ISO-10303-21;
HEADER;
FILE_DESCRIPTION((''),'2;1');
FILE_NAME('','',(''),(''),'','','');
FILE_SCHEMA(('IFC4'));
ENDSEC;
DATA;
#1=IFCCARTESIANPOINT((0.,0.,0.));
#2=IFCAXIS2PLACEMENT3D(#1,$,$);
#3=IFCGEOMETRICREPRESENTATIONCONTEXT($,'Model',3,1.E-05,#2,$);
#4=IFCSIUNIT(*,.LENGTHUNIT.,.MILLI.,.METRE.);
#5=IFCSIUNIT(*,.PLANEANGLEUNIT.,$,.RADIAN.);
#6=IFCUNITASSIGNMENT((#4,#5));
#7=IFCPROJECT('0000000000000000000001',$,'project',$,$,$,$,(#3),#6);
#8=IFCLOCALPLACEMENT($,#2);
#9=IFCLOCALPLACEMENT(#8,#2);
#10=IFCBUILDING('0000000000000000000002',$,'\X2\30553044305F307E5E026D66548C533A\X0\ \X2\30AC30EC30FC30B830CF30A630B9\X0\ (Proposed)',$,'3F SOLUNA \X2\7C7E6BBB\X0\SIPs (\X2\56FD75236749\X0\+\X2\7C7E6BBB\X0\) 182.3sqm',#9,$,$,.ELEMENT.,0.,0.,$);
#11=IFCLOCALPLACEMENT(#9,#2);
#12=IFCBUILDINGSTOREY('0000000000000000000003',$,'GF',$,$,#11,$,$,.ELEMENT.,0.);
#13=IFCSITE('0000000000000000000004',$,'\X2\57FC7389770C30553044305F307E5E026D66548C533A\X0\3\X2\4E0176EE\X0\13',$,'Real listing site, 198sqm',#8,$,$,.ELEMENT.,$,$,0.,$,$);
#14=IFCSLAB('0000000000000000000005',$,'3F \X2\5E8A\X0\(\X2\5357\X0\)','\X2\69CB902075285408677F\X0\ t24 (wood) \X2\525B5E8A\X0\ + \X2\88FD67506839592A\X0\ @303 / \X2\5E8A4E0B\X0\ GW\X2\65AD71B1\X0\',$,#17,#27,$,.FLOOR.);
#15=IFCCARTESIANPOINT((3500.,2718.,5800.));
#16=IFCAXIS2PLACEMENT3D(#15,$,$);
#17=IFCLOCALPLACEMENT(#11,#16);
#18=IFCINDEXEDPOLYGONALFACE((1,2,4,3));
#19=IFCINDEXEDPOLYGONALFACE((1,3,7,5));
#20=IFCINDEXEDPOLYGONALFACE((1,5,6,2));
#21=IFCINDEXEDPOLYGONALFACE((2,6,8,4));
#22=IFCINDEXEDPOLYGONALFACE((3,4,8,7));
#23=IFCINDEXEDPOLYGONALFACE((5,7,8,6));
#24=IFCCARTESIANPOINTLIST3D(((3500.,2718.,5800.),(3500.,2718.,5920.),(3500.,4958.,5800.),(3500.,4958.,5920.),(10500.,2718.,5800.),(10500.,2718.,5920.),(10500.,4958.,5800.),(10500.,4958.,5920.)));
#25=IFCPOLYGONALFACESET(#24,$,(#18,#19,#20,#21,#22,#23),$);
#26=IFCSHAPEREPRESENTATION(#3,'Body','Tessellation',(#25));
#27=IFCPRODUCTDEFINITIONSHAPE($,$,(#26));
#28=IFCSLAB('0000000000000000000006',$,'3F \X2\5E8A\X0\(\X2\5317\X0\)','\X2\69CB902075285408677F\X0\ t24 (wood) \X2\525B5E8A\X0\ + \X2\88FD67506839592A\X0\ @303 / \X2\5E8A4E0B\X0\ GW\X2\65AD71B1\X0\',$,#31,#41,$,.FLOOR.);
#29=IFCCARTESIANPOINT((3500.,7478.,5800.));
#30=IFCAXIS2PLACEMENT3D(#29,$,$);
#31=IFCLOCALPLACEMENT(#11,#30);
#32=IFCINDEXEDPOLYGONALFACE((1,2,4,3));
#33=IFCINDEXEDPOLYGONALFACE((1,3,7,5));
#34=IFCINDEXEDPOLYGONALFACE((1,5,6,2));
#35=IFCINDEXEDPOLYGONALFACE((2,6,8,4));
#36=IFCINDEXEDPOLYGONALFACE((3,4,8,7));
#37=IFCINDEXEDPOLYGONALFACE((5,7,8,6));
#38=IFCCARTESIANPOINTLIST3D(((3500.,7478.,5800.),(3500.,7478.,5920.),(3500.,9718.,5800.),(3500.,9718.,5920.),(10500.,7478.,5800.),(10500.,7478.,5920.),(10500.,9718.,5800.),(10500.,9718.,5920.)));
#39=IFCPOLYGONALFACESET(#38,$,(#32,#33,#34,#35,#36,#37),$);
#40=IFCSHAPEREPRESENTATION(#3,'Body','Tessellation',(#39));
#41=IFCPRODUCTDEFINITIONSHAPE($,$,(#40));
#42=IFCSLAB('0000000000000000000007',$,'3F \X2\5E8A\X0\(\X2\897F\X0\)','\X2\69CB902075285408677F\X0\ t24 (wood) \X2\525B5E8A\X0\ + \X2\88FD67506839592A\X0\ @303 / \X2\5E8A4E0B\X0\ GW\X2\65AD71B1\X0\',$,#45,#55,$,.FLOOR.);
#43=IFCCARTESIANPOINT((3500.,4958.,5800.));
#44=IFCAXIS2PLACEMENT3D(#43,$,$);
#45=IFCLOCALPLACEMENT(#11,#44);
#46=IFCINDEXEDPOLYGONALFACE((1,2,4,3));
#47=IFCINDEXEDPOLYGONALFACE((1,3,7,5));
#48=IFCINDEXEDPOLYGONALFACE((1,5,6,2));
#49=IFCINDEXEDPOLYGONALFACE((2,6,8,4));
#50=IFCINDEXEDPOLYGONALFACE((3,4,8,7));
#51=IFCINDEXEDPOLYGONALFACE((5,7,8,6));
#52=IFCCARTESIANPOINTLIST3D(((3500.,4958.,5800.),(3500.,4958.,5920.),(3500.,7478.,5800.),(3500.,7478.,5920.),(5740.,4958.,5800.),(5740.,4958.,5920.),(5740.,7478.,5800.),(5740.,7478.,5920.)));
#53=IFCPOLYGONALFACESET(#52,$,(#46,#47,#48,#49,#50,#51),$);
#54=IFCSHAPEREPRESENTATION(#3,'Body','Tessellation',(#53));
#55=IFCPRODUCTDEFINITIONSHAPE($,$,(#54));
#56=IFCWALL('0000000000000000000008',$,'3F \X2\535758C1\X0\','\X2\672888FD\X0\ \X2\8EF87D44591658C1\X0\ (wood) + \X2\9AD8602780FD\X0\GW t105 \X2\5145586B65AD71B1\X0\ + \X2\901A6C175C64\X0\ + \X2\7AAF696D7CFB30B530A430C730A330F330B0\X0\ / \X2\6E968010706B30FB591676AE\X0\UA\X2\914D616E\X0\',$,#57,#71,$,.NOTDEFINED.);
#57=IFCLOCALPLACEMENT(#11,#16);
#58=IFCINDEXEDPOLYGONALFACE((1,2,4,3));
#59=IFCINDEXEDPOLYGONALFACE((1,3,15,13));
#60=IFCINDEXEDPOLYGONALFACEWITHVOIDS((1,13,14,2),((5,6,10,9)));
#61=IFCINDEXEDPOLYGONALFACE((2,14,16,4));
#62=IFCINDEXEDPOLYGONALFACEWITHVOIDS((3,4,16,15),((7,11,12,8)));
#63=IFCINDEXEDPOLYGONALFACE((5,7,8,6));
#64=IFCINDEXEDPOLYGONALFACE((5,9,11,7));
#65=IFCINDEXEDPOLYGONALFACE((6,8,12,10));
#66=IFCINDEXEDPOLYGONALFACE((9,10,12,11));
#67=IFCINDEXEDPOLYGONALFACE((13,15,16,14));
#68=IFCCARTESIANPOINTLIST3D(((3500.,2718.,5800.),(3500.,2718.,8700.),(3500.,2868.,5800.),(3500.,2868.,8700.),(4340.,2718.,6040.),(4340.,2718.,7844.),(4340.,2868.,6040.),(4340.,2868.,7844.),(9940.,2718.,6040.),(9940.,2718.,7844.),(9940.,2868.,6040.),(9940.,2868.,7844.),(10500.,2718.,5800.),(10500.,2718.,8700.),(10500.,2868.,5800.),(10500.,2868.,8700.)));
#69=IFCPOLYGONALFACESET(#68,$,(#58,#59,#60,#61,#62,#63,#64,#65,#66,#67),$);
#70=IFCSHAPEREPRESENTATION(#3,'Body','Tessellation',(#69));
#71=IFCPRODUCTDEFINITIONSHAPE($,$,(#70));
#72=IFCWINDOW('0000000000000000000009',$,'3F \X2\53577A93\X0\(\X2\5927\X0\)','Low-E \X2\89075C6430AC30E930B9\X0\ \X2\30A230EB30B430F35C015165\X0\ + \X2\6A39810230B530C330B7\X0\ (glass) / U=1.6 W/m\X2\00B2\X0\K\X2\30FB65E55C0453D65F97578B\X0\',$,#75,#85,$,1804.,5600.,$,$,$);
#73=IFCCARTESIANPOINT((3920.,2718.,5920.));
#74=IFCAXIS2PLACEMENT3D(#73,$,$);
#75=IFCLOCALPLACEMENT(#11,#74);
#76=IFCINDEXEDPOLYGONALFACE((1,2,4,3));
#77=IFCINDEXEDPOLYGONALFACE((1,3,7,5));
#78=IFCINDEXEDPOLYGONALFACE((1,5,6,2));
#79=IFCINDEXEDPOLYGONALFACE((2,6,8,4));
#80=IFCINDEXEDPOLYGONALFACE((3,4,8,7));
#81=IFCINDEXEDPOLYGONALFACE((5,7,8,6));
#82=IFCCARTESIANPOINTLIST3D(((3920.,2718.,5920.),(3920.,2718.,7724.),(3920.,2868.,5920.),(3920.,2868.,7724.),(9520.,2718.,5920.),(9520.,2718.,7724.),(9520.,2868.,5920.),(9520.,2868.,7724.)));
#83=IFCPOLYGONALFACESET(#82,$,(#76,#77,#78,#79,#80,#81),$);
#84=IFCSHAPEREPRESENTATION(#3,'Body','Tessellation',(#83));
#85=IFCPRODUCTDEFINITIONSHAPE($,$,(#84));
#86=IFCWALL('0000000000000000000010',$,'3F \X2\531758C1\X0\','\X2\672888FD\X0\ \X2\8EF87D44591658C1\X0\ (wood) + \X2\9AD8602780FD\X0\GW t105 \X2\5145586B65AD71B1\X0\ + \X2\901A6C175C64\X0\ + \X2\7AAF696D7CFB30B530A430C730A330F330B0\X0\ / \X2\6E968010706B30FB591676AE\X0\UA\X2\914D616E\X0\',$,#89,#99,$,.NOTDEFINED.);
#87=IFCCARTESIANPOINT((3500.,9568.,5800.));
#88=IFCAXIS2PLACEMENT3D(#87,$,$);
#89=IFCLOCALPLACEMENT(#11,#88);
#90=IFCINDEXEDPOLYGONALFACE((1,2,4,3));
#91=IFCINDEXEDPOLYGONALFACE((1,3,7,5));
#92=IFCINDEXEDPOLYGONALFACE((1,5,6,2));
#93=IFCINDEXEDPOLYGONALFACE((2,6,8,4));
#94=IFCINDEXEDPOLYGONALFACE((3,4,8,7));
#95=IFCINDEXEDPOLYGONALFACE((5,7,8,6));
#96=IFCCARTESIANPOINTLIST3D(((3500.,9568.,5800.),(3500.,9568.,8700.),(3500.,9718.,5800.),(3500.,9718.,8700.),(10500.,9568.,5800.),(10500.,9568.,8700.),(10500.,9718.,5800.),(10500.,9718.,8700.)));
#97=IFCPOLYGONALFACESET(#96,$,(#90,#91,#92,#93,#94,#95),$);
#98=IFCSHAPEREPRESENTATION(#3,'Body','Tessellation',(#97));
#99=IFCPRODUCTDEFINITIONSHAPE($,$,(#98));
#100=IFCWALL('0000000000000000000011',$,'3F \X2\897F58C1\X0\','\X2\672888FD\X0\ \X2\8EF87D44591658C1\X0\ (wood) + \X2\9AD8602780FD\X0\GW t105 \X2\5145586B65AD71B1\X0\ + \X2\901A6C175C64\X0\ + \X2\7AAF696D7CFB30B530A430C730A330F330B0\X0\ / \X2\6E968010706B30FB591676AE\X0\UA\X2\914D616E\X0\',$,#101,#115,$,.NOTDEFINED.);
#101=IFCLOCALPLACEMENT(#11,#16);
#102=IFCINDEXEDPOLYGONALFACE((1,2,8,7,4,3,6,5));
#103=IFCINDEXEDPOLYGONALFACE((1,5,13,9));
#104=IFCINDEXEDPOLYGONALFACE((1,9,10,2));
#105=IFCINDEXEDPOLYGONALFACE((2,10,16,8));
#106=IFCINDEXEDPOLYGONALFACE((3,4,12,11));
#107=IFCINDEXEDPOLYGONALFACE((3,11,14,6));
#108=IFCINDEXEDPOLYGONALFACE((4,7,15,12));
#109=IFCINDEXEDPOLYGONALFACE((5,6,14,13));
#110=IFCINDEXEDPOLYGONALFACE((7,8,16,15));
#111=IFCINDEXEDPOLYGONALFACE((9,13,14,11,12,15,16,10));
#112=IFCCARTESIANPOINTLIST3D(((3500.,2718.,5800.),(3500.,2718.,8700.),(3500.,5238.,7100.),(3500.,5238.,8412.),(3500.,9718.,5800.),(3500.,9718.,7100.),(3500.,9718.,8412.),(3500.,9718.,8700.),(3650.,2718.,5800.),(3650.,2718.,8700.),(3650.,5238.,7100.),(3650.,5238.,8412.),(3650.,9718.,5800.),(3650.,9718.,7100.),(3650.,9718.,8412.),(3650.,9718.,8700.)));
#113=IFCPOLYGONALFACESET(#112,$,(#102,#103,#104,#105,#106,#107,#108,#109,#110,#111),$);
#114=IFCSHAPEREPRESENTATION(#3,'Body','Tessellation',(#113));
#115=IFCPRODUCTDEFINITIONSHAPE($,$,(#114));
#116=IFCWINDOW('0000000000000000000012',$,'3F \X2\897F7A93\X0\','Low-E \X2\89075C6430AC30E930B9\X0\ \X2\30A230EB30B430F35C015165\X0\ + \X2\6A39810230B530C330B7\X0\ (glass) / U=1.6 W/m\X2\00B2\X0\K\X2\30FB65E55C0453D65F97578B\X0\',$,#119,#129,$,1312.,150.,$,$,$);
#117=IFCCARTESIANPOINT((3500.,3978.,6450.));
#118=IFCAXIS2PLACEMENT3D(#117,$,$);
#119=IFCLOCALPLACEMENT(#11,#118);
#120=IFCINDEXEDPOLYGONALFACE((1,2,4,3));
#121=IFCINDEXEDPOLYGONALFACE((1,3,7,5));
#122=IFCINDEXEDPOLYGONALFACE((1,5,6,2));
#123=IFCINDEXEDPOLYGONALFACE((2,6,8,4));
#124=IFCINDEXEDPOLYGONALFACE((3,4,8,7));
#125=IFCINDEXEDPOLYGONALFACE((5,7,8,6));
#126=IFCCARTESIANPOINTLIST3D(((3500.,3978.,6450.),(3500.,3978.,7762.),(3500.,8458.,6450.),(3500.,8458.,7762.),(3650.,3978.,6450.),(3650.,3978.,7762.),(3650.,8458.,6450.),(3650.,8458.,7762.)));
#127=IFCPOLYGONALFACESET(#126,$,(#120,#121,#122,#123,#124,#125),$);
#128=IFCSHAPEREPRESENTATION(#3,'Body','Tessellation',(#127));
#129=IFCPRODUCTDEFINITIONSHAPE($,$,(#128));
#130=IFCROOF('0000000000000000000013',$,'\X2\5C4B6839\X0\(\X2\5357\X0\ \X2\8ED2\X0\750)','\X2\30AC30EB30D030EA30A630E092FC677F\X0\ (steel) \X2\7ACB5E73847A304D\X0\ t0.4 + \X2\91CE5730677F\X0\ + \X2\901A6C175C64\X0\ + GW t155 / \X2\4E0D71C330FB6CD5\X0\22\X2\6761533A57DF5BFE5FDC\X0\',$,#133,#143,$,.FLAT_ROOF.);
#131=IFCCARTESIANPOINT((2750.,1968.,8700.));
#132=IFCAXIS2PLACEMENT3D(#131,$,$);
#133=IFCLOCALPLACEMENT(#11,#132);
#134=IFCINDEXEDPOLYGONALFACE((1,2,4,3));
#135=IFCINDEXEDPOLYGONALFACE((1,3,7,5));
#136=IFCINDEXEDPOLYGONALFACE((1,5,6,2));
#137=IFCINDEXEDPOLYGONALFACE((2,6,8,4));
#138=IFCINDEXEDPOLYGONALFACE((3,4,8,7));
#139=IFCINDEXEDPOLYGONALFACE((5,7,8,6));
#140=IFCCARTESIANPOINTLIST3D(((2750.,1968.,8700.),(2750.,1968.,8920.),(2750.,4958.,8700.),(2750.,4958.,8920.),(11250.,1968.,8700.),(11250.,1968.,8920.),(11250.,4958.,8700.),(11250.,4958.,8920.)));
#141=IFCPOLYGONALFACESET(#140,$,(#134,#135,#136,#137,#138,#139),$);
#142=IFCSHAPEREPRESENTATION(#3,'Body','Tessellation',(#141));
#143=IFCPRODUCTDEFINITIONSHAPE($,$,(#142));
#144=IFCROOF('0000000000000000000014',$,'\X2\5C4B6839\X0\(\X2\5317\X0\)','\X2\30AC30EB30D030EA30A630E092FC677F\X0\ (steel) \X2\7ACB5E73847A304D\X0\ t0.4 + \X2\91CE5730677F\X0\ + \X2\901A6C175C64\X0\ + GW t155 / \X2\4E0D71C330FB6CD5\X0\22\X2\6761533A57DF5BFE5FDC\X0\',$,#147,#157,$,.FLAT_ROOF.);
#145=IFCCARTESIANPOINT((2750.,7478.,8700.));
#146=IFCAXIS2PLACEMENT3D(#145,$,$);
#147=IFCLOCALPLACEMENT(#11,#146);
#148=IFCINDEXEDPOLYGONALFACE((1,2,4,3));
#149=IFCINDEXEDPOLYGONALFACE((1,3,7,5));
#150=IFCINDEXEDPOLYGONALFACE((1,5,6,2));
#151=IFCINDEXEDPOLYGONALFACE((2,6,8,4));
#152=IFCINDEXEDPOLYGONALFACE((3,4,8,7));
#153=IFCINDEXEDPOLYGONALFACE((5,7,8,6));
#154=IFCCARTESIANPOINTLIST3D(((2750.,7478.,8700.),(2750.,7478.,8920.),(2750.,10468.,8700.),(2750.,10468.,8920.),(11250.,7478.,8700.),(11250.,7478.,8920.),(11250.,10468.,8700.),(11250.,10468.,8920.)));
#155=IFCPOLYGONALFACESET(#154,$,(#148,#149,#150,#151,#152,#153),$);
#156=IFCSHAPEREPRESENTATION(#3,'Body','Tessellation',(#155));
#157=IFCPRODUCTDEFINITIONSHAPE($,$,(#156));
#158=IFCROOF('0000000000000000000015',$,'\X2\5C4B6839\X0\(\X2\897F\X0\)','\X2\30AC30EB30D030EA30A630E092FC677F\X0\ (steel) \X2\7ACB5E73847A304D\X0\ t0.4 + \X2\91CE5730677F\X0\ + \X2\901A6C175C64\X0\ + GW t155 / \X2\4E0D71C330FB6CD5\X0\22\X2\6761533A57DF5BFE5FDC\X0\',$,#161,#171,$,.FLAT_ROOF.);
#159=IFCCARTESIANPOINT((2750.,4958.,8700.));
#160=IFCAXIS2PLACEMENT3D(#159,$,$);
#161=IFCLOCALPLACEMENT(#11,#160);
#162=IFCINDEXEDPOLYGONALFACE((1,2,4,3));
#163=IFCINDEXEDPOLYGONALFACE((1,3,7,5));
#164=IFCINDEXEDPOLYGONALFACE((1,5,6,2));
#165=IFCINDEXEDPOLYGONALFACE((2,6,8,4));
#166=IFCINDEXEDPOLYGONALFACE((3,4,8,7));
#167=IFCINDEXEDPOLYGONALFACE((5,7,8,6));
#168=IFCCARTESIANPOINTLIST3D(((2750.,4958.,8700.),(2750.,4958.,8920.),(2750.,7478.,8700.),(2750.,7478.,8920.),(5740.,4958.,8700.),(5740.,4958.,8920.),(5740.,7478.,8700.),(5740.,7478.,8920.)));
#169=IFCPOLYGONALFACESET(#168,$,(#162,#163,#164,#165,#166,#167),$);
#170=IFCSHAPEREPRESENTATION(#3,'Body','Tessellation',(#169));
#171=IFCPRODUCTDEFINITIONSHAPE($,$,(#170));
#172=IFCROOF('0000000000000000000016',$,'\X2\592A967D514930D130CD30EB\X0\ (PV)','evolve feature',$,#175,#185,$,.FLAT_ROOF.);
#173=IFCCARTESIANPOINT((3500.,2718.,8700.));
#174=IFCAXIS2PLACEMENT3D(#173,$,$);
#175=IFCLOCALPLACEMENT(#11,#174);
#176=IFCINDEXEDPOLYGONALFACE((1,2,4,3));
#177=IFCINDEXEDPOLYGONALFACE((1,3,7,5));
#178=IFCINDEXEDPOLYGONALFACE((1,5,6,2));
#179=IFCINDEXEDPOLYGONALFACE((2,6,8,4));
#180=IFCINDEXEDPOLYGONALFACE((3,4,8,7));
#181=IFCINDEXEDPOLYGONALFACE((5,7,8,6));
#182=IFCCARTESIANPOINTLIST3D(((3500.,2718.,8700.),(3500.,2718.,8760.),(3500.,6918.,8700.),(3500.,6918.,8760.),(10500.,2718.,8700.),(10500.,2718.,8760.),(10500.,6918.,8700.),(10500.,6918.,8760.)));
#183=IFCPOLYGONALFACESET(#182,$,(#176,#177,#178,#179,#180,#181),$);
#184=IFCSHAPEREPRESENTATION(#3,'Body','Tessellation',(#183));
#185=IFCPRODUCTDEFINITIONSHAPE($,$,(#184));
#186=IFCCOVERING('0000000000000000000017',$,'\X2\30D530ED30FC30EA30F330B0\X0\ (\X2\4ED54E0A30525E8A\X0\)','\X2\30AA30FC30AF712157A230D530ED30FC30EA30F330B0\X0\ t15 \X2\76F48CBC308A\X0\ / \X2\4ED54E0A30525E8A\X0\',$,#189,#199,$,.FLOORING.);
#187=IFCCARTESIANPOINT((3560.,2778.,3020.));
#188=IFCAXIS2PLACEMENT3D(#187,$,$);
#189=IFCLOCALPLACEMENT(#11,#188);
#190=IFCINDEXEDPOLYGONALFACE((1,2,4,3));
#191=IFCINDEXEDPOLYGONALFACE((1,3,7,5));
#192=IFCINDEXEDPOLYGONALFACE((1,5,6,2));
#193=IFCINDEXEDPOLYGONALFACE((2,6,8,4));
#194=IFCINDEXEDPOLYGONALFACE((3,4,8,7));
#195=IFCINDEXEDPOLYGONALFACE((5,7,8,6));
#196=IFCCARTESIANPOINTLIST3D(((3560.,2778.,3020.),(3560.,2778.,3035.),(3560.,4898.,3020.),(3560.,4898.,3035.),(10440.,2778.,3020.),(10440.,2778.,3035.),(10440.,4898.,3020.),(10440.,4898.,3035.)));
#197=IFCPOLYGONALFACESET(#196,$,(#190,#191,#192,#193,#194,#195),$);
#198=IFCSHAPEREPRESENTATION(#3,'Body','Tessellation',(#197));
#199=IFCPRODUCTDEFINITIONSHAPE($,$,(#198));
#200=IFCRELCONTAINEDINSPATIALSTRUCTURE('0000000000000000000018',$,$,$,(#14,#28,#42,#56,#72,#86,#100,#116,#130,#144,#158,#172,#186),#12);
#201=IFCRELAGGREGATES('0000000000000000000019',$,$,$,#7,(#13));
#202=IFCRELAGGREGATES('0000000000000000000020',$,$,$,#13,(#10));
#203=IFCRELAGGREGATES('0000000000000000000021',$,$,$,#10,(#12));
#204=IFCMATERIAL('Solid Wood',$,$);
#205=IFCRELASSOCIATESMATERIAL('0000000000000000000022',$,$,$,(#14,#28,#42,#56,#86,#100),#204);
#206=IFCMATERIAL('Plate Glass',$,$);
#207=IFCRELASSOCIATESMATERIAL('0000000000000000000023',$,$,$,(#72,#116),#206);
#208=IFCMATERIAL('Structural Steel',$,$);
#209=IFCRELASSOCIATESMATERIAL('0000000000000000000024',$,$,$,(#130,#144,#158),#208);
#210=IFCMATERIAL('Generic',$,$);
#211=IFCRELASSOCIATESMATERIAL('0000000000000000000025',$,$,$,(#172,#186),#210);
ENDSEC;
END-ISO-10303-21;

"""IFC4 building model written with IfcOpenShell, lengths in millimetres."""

from ifc_helpers import new_model, si_unit, frame, frame_2d, origin, place, context, project, spatial, rectangle, extrude, material, element, fill, save


model = new_model("IFC4")

# Units and contexts
model_context = context("Model", 3, precision=1e-05, world=origin())
ifc_project = project(units=[si_unit("LENGTHUNIT", "METRE", prefix="MILLI"), si_unit("PLANEANGLEUNIT", "RADIAN")], contexts=[model_context])

# Site, building, storey
site_placement = place(None, origin())
site = spatial("IfcSite", under=ifc_project, at=site_placement, Name="埼玉県さいたま市浦和区3丁目13", ObjectType="Real listing site, 198sqm", CompositionType="ELEMENT", RefElevation=0.0)
building_placement = place(site_placement, origin())
building = spatial("IfcBuilding", under=site, at=building_placement, Name="さいたま市浦和区 ガレージハウス (Proposed)", ObjectType="3F SOLUNA 籾殻SIPs (国産杉+籾殻) 182.3sqm", CompositionType="ELEMENT", ElevationOfRefHeight=0.0, ElevationOfTerrain=0.0)
storey_placement = place(building_placement, origin())
storey = spatial("IfcBuildingStorey", under=building, at=storey_placement, Name="GF", CompositionType="ELEMENT", Elevation=0.0)

# Slabs
ifc_material_1 = material(Name="Solid Wood")
slab_1_placement = place(storey_placement, frame((3500.0, 2718.0, 5800.0)))
element("IfcSlab", 1, at=slab_1_placement, inside=storey, material=ifc_material_1, Name="3F 床(南)", Description="構造用合板 t24 (wood) 剛床 + 製材根太 @303 / 床下 GW断熱", PredefinedType="FLOOR", context=model_context, shape_type="SweptSolid", body=[
    extrude(rectangle(XDim=7000.0, YDim=2240.0, at=frame_2d((3500.0, 1120.0))), frame((3500.0, 2718.0, 5800.0)), (0.0, 0.0, 1.0), 120.0),
])
slab_2_placement = place(storey_placement, frame((3500.0, 7478.0, 5800.0)))
element("IfcSlab", 2, at=slab_2_placement, inside=storey, material=ifc_material_1, Name="3F 床(北)", Description="構造用合板 t24 (wood) 剛床 + 製材根太 @303 / 床下 GW断熱", PredefinedType="FLOOR", context=model_context, shape_type="SweptSolid", body=[
    extrude(rectangle(XDim=7000.0, YDim=2240.0, at=frame_2d((3500.0, 1120.0))), frame((3500.0, 7478.0, 5800.0)), (0.0, 0.0, 1.0), 120.0),
])
slab_3_placement = place(storey_placement, frame((3500.0, 4958.0, 5800.0)))
element("IfcSlab", 3, at=slab_3_placement, inside=storey, material=ifc_material_1, Name="3F 床(西)", Description="構造用合板 t24 (wood) 剛床 + 製材根太 @303 / 床下 GW断熱", PredefinedType="FLOOR", context=model_context, shape_type="SweptSolid", body=[
    extrude(rectangle(XDim=2240.0, YDim=2520.0, at=frame_2d((1120.0, 1260.0))), frame((3500.0, 4958.0, 5800.0)), (0.0, 0.0, 1.0), 120.0),
])

# Wall, opening, window
wall_1_placement = place(storey_placement, frame((3500.0, 2718.0, 5800.0)))
wall_1 = element("IfcWall", 4, at=wall_1_placement, inside=storey, material=ifc_material_1, Name="3F 南壁", Description="木製 軸組外壁 (wood) + 高性能GW t105 充填断熱 + 通気層 + 窯業系サイディング / 準耐火・外皮UA配慮", PredefinedType="NOTDEFINED", context=model_context, shape_type="SweptSolid", body=[
    extrude(rectangle(XDim=7000.0, YDim=150.0, at=frame_2d((3500.0, 75.0))), frame((3500.0, 2718.0, 5800.0)), (0.0, 0.0, 1.0), 2900.0),
])
opening_1_placement = place(storey_placement, frame((3920.0, 2718.0, 5920.0)))
opening_1 = element("IfcOpeningElement", 5, at=opening_1_placement, cuts=wall_1, PredefinedType="NOTDEFINED", context=model_context, shape_type="SweptSolid", body=[
    extrude(rectangle(XDim=5600.0, YDim=150.0, at=frame_2d((2800.0, 75.0))), frame((3920.0, 2718.0, 5920.0)), (0.0, 0.0, 1.0), 1804.0),
])
ifc_material_2 = material(Name="Plate Glass")
window_1_placement = place(storey_placement, frame((3920.0, 2718.0, 5920.0)))
window_1 = element("IfcWindow", 6, at=window_1_placement, inside=storey, material=ifc_material_2, Name="3F 南窓(大)", Description="Low-E 複層ガラス アルゴン封入 + 樹脂サッシ (glass) / U=1.6 W/m²K・日射取得型", OverallHeight=1804.0, OverallWidth=5600.0, context=model_context, shape_type="SweptSolid", body=[
    extrude(rectangle(XDim=5600.0, YDim=150.0, at=frame_2d((2800.0, 75.0))), frame((3920.0, 2718.0, 5920.0)), (0.0, 0.0, 1.0), 1804.0),
])
fill(opening_1, window_1)

# Wall
wall_2_placement = place(storey_placement, frame((3500.0, 9568.0, 5800.0)))
element("IfcWall", 7, at=wall_2_placement, inside=storey, material=ifc_material_1, Name="3F 北壁", Description="木製 軸組外壁 (wood) + 高性能GW t105 充填断熱 + 通気層 + 窯業系サイディング / 準耐火・外皮UA配慮", PredefinedType="NOTDEFINED", context=model_context, shape_type="SweptSolid", body=[
    extrude(rectangle(XDim=7000.0, YDim=150.0, at=frame_2d((3500.0, 75.0))), frame((3500.0, 9568.0, 5800.0)), (0.0, 0.0, 1.0), 2900.0),
])

# Wall, opening, window
wall_3_placement = place(storey_placement, frame((3500.0, 2718.0, 5800.0)))
wall_3 = element("IfcWall", 8, at=wall_3_placement, inside=storey, material=ifc_material_1, Name="3F 西壁", Description="木製 軸組外壁 (wood) + 高性能GW t105 充填断熱 + 通気層 + 窯業系サイディング / 準耐火・外皮UA配慮", PredefinedType="NOTDEFINED", context=model_context, shape_type="SweptSolid", body=[
    extrude(rectangle(XDim=150.0, YDim=7000.0, at=frame_2d((75.0, 3500.0))), frame((3500.0, 2718.0, 5800.0)), (0.0, 0.0, 1.0), 2900.0),
])
opening_2_placement = place(storey_placement, frame((3500.0, 3978.0, 6450.0)))
opening_2 = element("IfcOpeningElement", 9, at=opening_2_placement, cuts=wall_3, PredefinedType="NOTDEFINED", context=model_context, shape_type="SweptSolid", body=[
    extrude(rectangle(XDim=150.0, YDim=4480.0, at=frame_2d((75.0, 2240.0))), frame((3500.0, 3978.0, 6450.0)), (0.0, 0.0, 1.0), 1312.0),
])
window_2_placement = place(storey_placement, frame((3500.0, 3978.0, 6450.0)))
window_2 = element("IfcWindow", 10, at=window_2_placement, inside=storey, material=ifc_material_2, Name="3F 西窓", Description="Low-E 複層ガラス アルゴン封入 + 樹脂サッシ (glass) / U=1.6 W/m²K・日射取得型", OverallHeight=1312.0, OverallWidth=150.0, context=model_context, shape_type="SweptSolid", body=[
    extrude(rectangle(XDim=150.0, YDim=4480.0, at=frame_2d((75.0, 2240.0))), frame((3500.0, 3978.0, 6450.0)), (0.0, 0.0, 1.0), 1312.0),
])
fill(opening_2, window_2)

# Roofs
ifc_material_3 = material(Name="Structural Steel")
roof_1_placement = place(storey_placement, frame((2750.0, 1968.0, 8700.0)))
element("IfcRoof", 11, at=roof_1_placement, inside=storey, material=ifc_material_3, Name="屋根(南 軒750)", Description="ガルバリウム鋼板 (steel) 立平葺き t0.4 + 野地板 + 通気層 + GW t155 / 不燃・法22条区域対応", PredefinedType="FLAT_ROOF", context=model_context, shape_type="SweptSolid", body=[
    extrude(rectangle(XDim=8500.0, YDim=2990.0, at=frame_2d((4250.0, 1495.0))), frame((2750.0, 1968.0, 8700.0)), (0.0, 0.0, 1.0), 220.0),
])
roof_2_placement = place(storey_placement, frame((2750.0, 7478.0, 8700.0)))
element("IfcRoof", 12, at=roof_2_placement, inside=storey, material=ifc_material_3, Name="屋根(北)", Description="ガルバリウム鋼板 (steel) 立平葺き t0.4 + 野地板 + 通気層 + GW t155 / 不燃・法22条区域対応", PredefinedType="FLAT_ROOF", context=model_context, shape_type="SweptSolid", body=[
    extrude(rectangle(XDim=8500.0, YDim=2990.0, at=frame_2d((4250.0, 1495.0))), frame((2750.0, 7478.0, 8700.0)), (0.0, 0.0, 1.0), 220.0),
])
roof_3_placement = place(storey_placement, frame((2750.0, 4958.0, 8700.0)))
element("IfcRoof", 13, at=roof_3_placement, inside=storey, material=ifc_material_3, Name="屋根(西)", Description="ガルバリウム鋼板 (steel) 立平葺き t0.4 + 野地板 + 通気層 + GW t155 / 不燃・法22条区域対応", PredefinedType="FLAT_ROOF", context=model_context, shape_type="SweptSolid", body=[
    extrude(rectangle(XDim=2990.0, YDim=2520.0, at=frame_2d((1495.0, 1260.0))), frame((2750.0, 4958.0, 8700.0)), (0.0, 0.0, 1.0), 220.0),
])
ifc_material_4 = material(Name="Generic")
roof_4_placement = place(storey_placement, frame((3500.0, 2718.0, 8700.0)))
element("IfcRoof", 14, at=roof_4_placement, inside=storey, material=ifc_material_4, Name="太陽光パネル (PV)", Description="evolve feature", PredefinedType="FLAT_ROOF", context=model_context, shape_type="SweptSolid", body=[
    extrude(rectangle(XDim=7000.0, YDim=4200.0, at=frame_2d((3500.0, 2100.0))), frame((3500.0, 2718.0, 8700.0)), (0.0, 0.0, 1.0), 60.0),
])

# Covering
covering_1_placement = place(storey_placement, frame((3560.0, 2778.0, 3020.0)))
element("IfcCovering", 15, at=covering_1_placement, inside=storey, material=ifc_material_4, Name="フローリング (仕上げ床)", Description="オーク無垢フローリング t15 直貼り / 仕上げ床", PredefinedType="FLOORING", context=model_context, shape_type="SweptSolid", body=[
    extrude(rectangle(XDim=6880.0, YDim=2120.0, at=frame_2d((3440.0, 1060.0))), frame((3560.0, 2778.0, 3020.0)), (0.0, 0.0, 1.0), 15.0),
])

save(model, "model.ifc")
